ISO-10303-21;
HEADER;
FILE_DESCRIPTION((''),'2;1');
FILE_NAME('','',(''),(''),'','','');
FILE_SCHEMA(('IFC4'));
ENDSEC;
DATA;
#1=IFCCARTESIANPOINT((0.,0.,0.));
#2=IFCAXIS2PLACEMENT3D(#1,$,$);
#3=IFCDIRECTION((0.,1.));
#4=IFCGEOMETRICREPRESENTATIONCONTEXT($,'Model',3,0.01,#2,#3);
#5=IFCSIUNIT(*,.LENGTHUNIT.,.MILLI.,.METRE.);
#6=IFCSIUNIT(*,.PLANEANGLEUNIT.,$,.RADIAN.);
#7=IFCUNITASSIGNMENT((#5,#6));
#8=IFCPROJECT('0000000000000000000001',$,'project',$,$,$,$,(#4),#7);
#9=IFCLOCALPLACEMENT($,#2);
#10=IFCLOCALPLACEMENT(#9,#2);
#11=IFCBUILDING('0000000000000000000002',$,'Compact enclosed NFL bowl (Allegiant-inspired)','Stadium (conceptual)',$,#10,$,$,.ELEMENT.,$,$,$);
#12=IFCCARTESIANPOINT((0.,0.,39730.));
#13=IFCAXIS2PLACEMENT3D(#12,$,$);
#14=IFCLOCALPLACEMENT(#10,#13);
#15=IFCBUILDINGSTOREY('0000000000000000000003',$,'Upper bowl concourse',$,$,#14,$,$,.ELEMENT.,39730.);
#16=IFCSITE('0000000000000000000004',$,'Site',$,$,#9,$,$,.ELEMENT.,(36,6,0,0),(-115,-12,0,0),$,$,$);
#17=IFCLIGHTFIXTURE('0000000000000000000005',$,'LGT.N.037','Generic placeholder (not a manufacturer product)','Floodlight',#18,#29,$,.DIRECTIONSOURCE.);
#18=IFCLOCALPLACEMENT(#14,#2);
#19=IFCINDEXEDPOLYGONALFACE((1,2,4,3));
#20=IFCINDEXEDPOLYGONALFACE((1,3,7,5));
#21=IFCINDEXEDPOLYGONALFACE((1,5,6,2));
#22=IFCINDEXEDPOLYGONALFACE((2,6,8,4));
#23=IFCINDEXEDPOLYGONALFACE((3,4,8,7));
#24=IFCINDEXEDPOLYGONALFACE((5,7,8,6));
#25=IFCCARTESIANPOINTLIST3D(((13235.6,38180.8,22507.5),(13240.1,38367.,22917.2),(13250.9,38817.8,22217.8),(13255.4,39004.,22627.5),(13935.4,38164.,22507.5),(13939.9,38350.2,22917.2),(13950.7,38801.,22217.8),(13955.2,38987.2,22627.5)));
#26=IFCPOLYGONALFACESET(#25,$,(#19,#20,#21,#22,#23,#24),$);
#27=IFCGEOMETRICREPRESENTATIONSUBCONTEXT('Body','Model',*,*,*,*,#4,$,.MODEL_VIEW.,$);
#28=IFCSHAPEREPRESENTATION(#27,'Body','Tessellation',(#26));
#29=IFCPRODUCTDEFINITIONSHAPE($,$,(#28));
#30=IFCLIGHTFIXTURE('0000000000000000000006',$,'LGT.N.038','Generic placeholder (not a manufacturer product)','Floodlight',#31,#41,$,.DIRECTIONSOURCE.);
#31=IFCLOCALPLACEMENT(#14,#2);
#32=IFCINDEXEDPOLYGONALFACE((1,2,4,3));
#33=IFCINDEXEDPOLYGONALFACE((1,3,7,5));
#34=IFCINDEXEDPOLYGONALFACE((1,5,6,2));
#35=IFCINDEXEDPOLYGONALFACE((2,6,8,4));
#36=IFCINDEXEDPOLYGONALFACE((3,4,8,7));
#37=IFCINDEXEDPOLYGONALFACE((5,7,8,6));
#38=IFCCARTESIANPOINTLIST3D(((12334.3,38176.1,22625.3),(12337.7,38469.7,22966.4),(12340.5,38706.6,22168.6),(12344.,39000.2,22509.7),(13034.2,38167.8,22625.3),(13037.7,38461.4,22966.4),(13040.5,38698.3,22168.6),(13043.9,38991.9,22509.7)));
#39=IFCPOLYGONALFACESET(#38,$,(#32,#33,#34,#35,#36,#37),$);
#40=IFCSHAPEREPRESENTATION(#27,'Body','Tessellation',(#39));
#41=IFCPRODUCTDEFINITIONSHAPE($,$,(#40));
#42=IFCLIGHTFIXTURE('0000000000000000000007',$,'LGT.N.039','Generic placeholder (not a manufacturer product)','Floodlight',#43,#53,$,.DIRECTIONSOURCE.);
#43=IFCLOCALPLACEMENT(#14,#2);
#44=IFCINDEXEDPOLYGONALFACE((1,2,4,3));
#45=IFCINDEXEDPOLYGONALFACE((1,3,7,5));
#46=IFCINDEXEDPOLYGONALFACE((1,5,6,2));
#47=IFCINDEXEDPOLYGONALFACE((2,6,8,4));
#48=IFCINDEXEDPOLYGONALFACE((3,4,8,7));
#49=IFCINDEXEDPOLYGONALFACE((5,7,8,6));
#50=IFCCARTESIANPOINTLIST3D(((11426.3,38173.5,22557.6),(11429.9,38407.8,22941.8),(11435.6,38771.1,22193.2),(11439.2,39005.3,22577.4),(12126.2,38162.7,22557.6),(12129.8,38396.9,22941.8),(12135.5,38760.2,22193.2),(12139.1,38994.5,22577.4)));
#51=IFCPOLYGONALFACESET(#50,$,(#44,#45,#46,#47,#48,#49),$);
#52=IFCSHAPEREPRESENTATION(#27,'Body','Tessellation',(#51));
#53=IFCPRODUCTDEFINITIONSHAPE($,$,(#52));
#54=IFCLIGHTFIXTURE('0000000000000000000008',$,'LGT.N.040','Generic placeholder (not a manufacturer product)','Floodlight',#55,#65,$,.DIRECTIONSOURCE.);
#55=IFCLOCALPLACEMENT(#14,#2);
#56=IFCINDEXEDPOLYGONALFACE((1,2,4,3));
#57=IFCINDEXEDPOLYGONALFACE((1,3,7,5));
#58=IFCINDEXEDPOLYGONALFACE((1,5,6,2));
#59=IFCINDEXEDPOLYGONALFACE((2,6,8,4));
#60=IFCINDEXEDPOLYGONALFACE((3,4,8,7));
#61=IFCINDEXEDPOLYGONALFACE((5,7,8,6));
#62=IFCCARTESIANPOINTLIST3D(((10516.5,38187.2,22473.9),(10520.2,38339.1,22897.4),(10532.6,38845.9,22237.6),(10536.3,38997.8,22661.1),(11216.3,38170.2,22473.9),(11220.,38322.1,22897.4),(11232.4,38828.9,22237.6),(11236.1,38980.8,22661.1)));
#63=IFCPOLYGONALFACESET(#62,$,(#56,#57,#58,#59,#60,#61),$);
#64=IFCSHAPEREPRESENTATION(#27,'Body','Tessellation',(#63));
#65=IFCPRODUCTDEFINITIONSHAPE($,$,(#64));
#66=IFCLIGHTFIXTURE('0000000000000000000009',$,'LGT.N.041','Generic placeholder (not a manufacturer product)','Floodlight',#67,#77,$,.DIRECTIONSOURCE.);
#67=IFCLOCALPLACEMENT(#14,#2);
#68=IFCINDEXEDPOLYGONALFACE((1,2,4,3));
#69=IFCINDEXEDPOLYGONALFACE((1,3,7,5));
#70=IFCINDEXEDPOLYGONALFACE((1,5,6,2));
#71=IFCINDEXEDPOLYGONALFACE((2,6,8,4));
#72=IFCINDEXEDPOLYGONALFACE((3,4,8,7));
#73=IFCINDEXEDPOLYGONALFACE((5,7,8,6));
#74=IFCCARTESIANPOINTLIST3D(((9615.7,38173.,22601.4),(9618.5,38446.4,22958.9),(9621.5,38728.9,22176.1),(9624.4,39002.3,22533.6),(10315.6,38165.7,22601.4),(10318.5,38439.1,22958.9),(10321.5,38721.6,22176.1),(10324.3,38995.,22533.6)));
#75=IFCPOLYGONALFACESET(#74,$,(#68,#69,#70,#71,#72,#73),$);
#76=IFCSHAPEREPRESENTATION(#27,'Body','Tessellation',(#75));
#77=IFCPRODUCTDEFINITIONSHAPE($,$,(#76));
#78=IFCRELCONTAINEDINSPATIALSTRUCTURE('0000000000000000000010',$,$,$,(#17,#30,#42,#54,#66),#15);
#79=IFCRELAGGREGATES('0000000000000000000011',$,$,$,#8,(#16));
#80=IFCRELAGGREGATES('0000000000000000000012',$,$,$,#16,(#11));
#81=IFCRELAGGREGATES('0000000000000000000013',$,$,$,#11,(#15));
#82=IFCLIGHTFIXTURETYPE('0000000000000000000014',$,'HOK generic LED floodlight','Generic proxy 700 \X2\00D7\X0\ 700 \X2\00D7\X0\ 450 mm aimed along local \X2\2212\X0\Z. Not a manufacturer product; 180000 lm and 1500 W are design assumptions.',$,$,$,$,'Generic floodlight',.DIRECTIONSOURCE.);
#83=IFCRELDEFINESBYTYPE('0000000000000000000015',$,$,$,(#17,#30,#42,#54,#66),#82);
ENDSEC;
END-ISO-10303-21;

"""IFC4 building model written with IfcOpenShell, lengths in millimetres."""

from ifc_helpers import new_model, si_unit, direction, frame, origin, place, context, subcontext, project, spatial, rectangle, extrude, source, transform, mapped, type_object, type_shapes, element, save


model = new_model("IFC4")

# Units and contexts
model_context = context("Model", 3, precision=0.01, world=origin(), true_north=direction((0.0, 1.0)))
body_context = subcontext(model_context, "Body", "Model", "MODEL_VIEW")
ifc_project = project(units=[si_unit("LENGTHUNIT", "METRE", prefix="MILLI"), si_unit("PLANEANGLEUNIT", "RADIAN")], contexts=[model_context])

# Site, building, storey
site_placement = place(None, origin())
site = spatial("IfcSite", under=ifc_project, at=site_placement, Name="Site", CompositionType="ELEMENT", RefLatitude=(36, 6, 0, 0), RefLongitude=(-115, -12, 0, 0))
building_placement = place(site_placement, origin())
building = spatial("IfcBuilding", under=site, at=building_placement, Name="Compact enclosed NFL bowl (Allegiant-inspired)", Description="Stadium (conceptual)", CompositionType="ELEMENT")
storey_placement = place(building_placement, frame((0.0, 0.0, 39730.0)))
storey = spatial("IfcBuildingStorey", under=building, at=storey_placement, Name="Upper bowl concourse", CompositionType="ELEMENT", Elevation=39730.0)

# Light fixtures
light_fixture_type = type_object("IfcLightFixtureType", Name="HOK generic LED floodlight", Description="Generic proxy 700 × 700 × 450 mm aimed along local −Z. Not a manufacturer product; 180000 lm and 1500 W are design assumptions.", ElementType="Generic floodlight", PredefinedType="DIRECTIONSOURCE")
shared_shape = source(origin(), body_context, "Body", "SweptSolid", [
    extrude(rectangle(XDim=700.0, YDim=700.0), frame((0.0, 0.0, -225.0)), (0.0, 0.0, 1.0), 450.0),
])
type_shapes(light_fixture_type, [shared_shape])
for number, where, z_axis, x_axis, name in (
    (1, (13595.4, 38584.0, 22567.5), (0.009934, 0.413708, 0.910355), (-0.999712, 0.024004, 0.0), "LGT.N.037"),
    (2, (12689.1, 38584.0, 22567.5), (0.007718, 0.65239, 0.757844), (-0.99993, 0.01183, 0.0), "LGT.N.038"),
    (3, (11782.7, 38584.0, 22567.5), (0.008074, 0.520542, 0.853798), (-0.99988, 0.015509, 0.0), "LGT.N.039"),
    (4, (10876.3, 38584.0, 22567.5), (0.008217, 0.337465, 0.941302), (-0.999704, 0.024342, 0.0), "LGT.N.040"),
    (5, (9970.0, 38584.0, 22567.5), (0.006356, 0.607541, 0.794263), (-0.999945, 0.010461, 0.0), "LGT.N.041"),
):
    element("IfcLightFixture", number, at=place(storey_placement, frame(where, z_axis=z_axis, x_axis=x_axis)), inside=storey, type_object=light_fixture_type, Name=name, Description="Generic placeholder (not a manufacturer product)", ObjectType="Floodlight", PredefinedType="DIRECTIONSOURCE", context=body_context, shape_type="MappedRepresentation", body=[
        mapped(shared_shape, transform((0.0, 0.0, 0.0))),
    ])

save(model, "model.ifc")
